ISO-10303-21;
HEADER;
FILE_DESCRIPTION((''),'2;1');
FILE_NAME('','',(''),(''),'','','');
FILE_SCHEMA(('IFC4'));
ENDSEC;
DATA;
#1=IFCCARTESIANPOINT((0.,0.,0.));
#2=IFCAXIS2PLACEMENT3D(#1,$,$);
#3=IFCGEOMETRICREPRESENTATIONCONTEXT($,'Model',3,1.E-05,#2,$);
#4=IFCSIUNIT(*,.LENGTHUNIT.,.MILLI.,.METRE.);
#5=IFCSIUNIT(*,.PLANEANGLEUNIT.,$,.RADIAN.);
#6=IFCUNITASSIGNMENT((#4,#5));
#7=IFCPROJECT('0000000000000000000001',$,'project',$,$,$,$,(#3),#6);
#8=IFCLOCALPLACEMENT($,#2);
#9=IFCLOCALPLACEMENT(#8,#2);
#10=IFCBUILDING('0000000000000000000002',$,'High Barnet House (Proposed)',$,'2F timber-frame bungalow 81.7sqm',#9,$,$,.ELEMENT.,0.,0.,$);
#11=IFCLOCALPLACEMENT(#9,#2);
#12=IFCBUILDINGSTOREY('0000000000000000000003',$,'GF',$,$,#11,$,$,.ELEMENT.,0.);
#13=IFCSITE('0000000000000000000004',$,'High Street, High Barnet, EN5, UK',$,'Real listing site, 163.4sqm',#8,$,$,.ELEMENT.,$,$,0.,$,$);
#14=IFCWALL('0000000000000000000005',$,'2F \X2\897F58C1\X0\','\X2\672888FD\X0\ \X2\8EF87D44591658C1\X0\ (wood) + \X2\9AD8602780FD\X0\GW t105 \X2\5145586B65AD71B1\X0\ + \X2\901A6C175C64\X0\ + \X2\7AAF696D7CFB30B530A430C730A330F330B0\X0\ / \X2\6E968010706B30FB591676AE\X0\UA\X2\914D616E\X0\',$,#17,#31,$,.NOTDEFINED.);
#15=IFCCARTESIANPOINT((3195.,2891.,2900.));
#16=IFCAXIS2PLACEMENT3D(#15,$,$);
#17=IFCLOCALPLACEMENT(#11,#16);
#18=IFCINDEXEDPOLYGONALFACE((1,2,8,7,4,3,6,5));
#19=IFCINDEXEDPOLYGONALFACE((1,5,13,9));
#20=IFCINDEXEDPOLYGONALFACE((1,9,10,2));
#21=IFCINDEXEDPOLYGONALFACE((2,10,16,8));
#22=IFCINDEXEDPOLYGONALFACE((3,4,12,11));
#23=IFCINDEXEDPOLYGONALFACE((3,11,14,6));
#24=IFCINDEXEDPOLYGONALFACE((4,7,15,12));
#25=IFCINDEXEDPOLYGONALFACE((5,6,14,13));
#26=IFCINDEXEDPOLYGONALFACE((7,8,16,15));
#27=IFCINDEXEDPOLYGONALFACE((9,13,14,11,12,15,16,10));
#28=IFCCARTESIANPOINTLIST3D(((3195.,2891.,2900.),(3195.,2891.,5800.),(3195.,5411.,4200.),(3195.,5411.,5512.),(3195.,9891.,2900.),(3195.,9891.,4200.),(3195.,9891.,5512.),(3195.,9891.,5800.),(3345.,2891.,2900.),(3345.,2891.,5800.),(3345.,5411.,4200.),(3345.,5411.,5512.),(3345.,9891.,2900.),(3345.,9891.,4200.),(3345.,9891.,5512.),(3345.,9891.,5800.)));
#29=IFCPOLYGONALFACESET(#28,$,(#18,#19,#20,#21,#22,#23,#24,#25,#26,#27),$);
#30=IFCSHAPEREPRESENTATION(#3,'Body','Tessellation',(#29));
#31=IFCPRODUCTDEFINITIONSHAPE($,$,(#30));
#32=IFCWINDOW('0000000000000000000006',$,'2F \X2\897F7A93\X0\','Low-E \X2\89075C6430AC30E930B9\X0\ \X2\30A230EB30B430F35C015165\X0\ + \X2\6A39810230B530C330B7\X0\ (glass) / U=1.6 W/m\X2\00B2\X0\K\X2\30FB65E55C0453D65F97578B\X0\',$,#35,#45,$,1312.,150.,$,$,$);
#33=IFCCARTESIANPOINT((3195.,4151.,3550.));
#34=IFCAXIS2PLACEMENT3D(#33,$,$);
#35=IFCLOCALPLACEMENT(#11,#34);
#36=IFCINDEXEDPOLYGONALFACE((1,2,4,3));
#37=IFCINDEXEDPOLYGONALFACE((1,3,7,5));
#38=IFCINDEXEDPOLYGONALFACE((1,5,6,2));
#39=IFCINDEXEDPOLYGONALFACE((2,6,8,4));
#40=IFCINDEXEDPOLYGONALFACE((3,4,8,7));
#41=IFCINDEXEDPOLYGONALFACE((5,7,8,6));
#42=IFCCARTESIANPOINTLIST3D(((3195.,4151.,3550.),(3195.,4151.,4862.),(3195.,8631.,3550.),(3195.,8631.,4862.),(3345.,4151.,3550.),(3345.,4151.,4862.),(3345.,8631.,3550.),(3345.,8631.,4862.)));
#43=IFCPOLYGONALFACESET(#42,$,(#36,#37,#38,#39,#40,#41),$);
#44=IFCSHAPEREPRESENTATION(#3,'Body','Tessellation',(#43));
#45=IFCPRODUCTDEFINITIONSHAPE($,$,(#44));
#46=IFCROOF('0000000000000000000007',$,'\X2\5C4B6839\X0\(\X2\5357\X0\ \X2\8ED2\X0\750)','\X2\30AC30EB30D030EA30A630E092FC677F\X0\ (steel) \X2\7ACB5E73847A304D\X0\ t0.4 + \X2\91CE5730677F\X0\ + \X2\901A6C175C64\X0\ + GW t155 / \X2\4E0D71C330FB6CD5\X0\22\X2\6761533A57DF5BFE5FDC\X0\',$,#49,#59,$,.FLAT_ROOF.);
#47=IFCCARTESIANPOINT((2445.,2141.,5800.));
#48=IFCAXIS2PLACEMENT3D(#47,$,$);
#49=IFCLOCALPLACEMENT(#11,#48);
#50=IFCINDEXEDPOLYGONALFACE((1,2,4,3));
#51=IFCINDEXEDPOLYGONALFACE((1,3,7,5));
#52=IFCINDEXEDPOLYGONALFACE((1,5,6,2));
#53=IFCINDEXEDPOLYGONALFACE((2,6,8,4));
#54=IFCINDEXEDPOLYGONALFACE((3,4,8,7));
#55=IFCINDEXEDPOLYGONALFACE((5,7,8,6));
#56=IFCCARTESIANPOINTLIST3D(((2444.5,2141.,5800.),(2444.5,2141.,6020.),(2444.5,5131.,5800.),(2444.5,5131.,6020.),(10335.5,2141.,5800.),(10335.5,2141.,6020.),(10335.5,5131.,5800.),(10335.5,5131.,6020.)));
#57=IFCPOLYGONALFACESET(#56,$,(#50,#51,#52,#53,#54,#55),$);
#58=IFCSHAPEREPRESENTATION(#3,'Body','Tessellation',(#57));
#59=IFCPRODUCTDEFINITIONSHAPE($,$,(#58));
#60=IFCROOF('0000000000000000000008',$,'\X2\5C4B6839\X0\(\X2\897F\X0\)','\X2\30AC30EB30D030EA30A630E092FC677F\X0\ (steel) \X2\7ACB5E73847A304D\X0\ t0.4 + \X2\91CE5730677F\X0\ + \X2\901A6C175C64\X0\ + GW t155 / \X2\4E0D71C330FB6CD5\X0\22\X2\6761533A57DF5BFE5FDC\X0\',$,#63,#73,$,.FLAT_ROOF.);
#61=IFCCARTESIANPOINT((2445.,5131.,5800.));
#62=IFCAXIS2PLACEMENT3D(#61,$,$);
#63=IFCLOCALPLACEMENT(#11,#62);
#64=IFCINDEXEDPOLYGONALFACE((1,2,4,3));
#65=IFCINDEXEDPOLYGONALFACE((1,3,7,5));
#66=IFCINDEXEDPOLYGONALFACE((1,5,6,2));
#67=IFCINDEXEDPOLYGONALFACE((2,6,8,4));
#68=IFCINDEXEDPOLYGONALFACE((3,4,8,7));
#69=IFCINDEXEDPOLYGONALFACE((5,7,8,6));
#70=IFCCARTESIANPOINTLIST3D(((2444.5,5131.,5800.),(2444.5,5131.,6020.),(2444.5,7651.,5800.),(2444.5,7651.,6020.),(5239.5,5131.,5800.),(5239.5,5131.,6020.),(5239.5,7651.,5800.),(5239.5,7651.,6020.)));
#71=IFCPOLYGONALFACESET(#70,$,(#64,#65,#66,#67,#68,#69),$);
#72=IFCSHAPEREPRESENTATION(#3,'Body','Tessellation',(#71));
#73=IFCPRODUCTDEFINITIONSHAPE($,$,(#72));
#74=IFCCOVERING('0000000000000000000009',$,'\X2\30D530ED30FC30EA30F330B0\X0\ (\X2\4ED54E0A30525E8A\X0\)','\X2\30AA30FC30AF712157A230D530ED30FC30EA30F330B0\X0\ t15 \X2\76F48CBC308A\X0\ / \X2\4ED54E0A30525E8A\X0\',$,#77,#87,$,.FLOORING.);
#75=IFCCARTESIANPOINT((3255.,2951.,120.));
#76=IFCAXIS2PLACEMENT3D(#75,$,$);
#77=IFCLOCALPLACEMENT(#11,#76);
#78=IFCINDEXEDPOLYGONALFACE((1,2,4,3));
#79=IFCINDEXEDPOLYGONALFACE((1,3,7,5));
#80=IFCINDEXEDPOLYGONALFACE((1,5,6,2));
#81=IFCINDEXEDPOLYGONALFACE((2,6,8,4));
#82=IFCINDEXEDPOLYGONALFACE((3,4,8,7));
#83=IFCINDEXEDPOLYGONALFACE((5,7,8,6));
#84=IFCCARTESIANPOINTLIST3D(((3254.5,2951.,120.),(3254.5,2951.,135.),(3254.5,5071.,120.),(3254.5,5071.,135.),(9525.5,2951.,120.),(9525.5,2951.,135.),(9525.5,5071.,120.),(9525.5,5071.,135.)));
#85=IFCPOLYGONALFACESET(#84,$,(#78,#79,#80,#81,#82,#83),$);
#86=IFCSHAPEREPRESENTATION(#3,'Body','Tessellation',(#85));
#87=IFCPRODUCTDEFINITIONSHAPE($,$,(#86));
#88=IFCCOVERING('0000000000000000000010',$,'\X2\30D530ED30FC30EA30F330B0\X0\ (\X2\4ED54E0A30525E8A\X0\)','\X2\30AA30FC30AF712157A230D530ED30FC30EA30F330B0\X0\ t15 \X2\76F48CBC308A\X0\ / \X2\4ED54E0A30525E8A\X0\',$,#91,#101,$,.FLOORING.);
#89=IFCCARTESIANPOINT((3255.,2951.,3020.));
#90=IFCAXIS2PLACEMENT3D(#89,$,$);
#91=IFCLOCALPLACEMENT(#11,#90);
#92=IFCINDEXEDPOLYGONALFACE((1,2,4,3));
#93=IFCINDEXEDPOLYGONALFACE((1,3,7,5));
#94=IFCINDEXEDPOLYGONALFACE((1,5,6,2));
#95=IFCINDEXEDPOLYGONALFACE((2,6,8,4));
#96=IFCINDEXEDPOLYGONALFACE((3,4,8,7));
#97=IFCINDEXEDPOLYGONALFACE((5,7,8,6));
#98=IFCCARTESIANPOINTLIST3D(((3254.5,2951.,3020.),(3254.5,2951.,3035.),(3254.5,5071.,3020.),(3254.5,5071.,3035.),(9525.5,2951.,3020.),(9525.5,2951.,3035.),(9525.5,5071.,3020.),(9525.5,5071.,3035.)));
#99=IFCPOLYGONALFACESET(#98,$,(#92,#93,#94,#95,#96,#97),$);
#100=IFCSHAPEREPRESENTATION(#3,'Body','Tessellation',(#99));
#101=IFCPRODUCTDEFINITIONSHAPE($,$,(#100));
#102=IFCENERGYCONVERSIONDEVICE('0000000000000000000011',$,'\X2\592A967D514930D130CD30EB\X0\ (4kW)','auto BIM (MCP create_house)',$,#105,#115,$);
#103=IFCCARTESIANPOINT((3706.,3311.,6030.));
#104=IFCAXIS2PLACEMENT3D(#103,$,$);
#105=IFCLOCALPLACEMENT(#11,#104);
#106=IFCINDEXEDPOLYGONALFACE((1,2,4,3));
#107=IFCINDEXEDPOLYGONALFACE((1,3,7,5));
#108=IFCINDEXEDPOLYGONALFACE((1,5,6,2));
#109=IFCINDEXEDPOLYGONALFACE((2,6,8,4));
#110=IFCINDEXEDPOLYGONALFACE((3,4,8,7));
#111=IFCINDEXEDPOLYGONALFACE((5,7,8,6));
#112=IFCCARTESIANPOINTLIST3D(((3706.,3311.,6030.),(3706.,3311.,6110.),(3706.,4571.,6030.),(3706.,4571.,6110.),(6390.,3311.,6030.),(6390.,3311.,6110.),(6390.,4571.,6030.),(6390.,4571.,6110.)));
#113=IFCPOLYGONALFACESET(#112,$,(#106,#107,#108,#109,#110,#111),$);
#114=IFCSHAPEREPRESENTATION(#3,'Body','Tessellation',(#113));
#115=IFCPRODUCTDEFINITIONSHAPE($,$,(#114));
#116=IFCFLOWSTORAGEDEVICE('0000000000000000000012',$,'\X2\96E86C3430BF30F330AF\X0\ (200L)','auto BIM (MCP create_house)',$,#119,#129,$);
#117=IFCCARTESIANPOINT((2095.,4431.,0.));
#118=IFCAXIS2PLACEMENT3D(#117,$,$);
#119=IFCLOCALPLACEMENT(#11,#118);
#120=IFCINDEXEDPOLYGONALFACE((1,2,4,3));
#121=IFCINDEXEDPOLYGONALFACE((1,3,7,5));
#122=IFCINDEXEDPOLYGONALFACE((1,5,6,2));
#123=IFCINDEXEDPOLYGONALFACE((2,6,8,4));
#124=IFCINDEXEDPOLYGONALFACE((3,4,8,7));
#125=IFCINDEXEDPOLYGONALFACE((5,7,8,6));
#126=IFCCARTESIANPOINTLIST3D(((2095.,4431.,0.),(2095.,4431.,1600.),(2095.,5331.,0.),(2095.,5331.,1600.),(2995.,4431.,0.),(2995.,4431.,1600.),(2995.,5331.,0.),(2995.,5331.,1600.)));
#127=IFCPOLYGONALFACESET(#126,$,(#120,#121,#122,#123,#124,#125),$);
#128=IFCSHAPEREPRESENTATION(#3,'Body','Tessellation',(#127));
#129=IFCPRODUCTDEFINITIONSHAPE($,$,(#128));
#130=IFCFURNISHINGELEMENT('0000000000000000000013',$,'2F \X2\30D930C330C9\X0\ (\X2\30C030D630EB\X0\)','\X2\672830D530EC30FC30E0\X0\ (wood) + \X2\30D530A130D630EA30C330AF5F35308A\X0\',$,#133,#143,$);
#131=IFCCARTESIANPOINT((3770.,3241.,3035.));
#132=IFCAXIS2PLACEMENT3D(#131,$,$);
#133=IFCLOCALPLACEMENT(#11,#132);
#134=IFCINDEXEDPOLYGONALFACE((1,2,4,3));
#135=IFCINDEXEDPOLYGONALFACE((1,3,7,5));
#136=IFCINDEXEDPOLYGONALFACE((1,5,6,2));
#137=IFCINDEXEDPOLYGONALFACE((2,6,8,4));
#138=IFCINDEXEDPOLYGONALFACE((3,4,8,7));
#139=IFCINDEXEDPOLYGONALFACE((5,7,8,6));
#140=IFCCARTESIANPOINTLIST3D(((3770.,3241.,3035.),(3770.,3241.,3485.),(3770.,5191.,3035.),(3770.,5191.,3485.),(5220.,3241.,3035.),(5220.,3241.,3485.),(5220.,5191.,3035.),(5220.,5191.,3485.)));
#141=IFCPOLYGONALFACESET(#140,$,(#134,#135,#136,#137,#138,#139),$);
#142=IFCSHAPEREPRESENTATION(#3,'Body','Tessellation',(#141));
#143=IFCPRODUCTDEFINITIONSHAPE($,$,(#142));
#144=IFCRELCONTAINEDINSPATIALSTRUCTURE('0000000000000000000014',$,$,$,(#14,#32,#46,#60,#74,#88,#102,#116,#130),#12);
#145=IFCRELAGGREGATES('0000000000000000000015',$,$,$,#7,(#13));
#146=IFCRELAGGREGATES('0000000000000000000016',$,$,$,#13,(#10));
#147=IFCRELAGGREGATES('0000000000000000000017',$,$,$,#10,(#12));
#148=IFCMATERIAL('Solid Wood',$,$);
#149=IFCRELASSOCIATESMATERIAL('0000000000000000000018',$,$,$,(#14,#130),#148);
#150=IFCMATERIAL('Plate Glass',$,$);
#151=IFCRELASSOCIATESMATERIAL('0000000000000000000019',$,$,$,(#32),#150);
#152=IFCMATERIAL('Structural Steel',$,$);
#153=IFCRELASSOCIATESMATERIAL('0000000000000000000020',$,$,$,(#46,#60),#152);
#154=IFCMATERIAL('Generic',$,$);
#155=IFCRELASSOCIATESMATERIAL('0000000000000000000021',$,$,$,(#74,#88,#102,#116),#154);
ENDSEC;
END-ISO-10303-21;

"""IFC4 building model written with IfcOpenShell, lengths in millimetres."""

from ifc_helpers import new_model, si_unit, frame, frame_2d, origin, place, context, project, spatial, rectangle, extrude, material, element, fill, save


model = new_model("IFC4")

# Units and contexts
model_context = context("Model", 3, precision=1e-05, world=origin())
ifc_project = project(units=[si_unit("LENGTHUNIT", "METRE", prefix="MILLI"), si_unit("PLANEANGLEUNIT", "RADIAN")], contexts=[model_context])

# Site, building, storey
site_placement = place(None, origin())
site = spatial("IfcSite", under=ifc_project, at=site_placement, Name="High Street, High Barnet, EN5, UK", ObjectType="Real listing site, 163.4sqm", CompositionType="ELEMENT", RefElevation=0.0)
building_placement = place(site_placement, origin())
building = spatial("IfcBuilding", under=site, at=building_placement, Name="High Barnet House (Proposed)", ObjectType="2F timber-frame bungalow 81.7sqm", CompositionType="ELEMENT", ElevationOfRefHeight=0.0, ElevationOfTerrain=0.0)
storey_placement = place(building_placement, origin())
storey = spatial("IfcBuildingStorey", under=building, at=storey_placement, Name="GF", CompositionType="ELEMENT", Elevation=0.0)

# Shared definitions
ifc_material_1 = material(Name="Solid Wood")

# Shared definitions
ifc_material_2 = material(Name="Plate Glass")

# Wall, opening, window
wall_1_placement = place(storey_placement, frame((3195.0, 2891.0, 2900.0)))
wall_1 = element("IfcWall", 1, at=wall_1_placement, inside=storey, material=ifc_material_1, Name="2F 西壁", Description="木製 軸組外壁 (wood) + 高性能GW t105 充填断熱 + 通気層 + 窯業系サイディング / 準耐火・外皮UA配慮", PredefinedType="NOTDEFINED", context=model_context, shape_type="SweptSolid", body=[
    extrude(rectangle(XDim=150.0, YDim=7000.0, at=frame_2d((75.0, 3500.0))), frame((3195.0, 2891.0, 2900.0)), (0.0, 0.0, 1.0), 2900.0),
])
opening_1_placement = place(storey_placement, frame((3195.0, 4151.0, 3550.0)))
opening_1 = element("IfcOpeningElement", 2, at=opening_1_placement, cuts=wall_1, PredefinedType="NOTDEFINED", context=model_context, shape_type="SweptSolid", body=[
    extrude(rectangle(XDim=150.0, YDim=4480.0, at=frame_2d((75.0, 2240.0))), frame((3195.0, 4151.0, 3550.0)), (0.0, 0.0, 1.0), 1312.0),
])
window_1_placement = place(storey_placement, frame((3195.0, 4151.0, 3550.0)))
window_1 = element("IfcWindow", 3, at=window_1_placement, inside=storey, material=ifc_material_2, Name="2F 西窓", Description="Low-E 複層ガラス アルゴン封入 + 樹脂サッシ (glass) / U=1.6 W/m²K・日射取得型", OverallHeight=1312.0, OverallWidth=150.0, context=model_context, shape_type="SweptSolid", body=[
    extrude(rectangle(XDim=150.0, YDim=4480.0, at=frame_2d((75.0, 2240.0))), frame((3195.0, 4151.0, 3550.0)), (0.0, 0.0, 1.0), 1312.0),
])
fill(opening_1, window_1)

# Roofs
ifc_material_3 = material(Name="Structural Steel")
roof_1_placement = place(storey_placement, frame((2445.0, 2141.0, 5800.0)))
element("IfcRoof", 4, at=roof_1_placement, inside=storey, material=ifc_material_3, Name="屋根(南 軒750)", Description="ガルバリウム鋼板 (steel) 立平葺き t0.4 + 野地板 + 通気層 + GW t155 / 不燃・法22条区域対応", PredefinedType="FLAT_ROOF", context=model_context, shape_type="SweptSolid", body=[
    extrude(rectangle(XDim=7891.0, YDim=2990.0, at=frame_2d((3945.0, 1495.0))), frame((2445.0, 2141.0, 5800.0)), (0.0, 0.0, 1.0), 220.0),
])
roof_2_placement = place(storey_placement, frame((2445.0, 5131.0, 5800.0)))
element("IfcRoof", 5, at=roof_2_placement, inside=storey, material=ifc_material_3, Name="屋根(西)", Description="ガルバリウム鋼板 (steel) 立平葺き t0.4 + 野地板 + 通気層 + GW t155 / 不燃・法22条区域対応", PredefinedType="FLAT_ROOF", context=model_context, shape_type="SweptSolid", body=[
    extrude(rectangle(XDim=2795.0, YDim=2520.0, at=frame_2d((1397.0, 1260.0))), frame((2445.0, 5131.0, 5800.0)), (0.0, 0.0, 1.0), 220.0),
])

# Coverings
ifc_material_4 = material(Name="Generic")
covering_1_placement = place(storey_placement, frame((3255.0, 2951.0, 120.0)))
element("IfcCovering", 6, at=covering_1_placement, inside=storey, material=ifc_material_4, Name="フローリング (仕上げ床)", Description="オーク無垢フローリング t15 直貼り / 仕上げ床", PredefinedType="FLOORING", context=model_context, shape_type="SweptSolid", body=[
    extrude(rectangle(XDim=6271.0, YDim=2120.0, at=frame_2d((3135.0, 1060.0))), frame((3255.0, 2951.0, 120.0)), (0.0, 0.0, 1.0), 15.0),
])
covering_2_placement = place(storey_placement, frame((3255.0, 2951.0, 3020.0)))
element("IfcCovering", 7, at=covering_2_placement, inside=storey, material=ifc_material_4, Name="フローリング (仕上げ床)", Description="オーク無垢フローリング t15 直貼り / 仕上げ床", PredefinedType="FLOORING", context=model_context, shape_type="SweptSolid", body=[
    extrude(rectangle(XDim=6271.0, YDim=2120.0, at=frame_2d((3135.0, 1060.0))), frame((3255.0, 2951.0, 3020.0)), (0.0, 0.0, 1.0), 15.0),
])

# Energy conversion device
energy_conversion_device_placement = place(storey_placement, frame((3706.0, 3311.0, 6030.0)))
element("IfcEnergyConversionDevice", 8, at=energy_conversion_device_placement, inside=storey, material=ifc_material_4, Name="太陽光パネル (4kW)", Description="auto BIM (MCP create_house)", context=model_context, shape_type="SweptSolid", body=[
    extrude(rectangle(XDim=2684.0, YDim=1260.0, at=frame_2d((1342.0, 630.0))), frame((3706.0, 3311.0, 6030.0)), (0.0, 0.0, 1.0), 80.0),
])

# Flow storage device
flow_storage_device_placement = place(storey_placement, frame((2095.0, 4431.0, 0.0)))
element("IfcFlowStorageDevice", 9, at=flow_storage_device_placement, inside=storey, material=ifc_material_4, Name="雨水タンク (200L)", Description="auto BIM (MCP create_house)", context=model_context, shape_type="SweptSolid", body=[
    extrude(rectangle(XDim=900.0, YDim=900.0, at=frame_2d((450.0, 450.0))), frame((2095.0, 4431.0, 0.0)), (0.0, 0.0, 1.0), 1600.0),
])

# Furnishing element
furnishing_placement = place(storey_placement, frame((3770.0, 3241.0, 3035.0)))
element("IfcFurnishingElement", 10, at=furnishing_placement, inside=storey, material=ifc_material_1, Name="2F ベッド (ダブル)", Description="木フレーム (wood) + ファブリック張り", context=model_context, shape_type="SweptSolid", body=[
    extrude(rectangle(XDim=1450.0, YDim=1950.0, at=frame_2d((725.0, 975.0))), frame((3770.0, 3241.0, 3035.0)), (0.0, 0.0, 1.0), 450.0),
])

save(model, "model.ifc")
